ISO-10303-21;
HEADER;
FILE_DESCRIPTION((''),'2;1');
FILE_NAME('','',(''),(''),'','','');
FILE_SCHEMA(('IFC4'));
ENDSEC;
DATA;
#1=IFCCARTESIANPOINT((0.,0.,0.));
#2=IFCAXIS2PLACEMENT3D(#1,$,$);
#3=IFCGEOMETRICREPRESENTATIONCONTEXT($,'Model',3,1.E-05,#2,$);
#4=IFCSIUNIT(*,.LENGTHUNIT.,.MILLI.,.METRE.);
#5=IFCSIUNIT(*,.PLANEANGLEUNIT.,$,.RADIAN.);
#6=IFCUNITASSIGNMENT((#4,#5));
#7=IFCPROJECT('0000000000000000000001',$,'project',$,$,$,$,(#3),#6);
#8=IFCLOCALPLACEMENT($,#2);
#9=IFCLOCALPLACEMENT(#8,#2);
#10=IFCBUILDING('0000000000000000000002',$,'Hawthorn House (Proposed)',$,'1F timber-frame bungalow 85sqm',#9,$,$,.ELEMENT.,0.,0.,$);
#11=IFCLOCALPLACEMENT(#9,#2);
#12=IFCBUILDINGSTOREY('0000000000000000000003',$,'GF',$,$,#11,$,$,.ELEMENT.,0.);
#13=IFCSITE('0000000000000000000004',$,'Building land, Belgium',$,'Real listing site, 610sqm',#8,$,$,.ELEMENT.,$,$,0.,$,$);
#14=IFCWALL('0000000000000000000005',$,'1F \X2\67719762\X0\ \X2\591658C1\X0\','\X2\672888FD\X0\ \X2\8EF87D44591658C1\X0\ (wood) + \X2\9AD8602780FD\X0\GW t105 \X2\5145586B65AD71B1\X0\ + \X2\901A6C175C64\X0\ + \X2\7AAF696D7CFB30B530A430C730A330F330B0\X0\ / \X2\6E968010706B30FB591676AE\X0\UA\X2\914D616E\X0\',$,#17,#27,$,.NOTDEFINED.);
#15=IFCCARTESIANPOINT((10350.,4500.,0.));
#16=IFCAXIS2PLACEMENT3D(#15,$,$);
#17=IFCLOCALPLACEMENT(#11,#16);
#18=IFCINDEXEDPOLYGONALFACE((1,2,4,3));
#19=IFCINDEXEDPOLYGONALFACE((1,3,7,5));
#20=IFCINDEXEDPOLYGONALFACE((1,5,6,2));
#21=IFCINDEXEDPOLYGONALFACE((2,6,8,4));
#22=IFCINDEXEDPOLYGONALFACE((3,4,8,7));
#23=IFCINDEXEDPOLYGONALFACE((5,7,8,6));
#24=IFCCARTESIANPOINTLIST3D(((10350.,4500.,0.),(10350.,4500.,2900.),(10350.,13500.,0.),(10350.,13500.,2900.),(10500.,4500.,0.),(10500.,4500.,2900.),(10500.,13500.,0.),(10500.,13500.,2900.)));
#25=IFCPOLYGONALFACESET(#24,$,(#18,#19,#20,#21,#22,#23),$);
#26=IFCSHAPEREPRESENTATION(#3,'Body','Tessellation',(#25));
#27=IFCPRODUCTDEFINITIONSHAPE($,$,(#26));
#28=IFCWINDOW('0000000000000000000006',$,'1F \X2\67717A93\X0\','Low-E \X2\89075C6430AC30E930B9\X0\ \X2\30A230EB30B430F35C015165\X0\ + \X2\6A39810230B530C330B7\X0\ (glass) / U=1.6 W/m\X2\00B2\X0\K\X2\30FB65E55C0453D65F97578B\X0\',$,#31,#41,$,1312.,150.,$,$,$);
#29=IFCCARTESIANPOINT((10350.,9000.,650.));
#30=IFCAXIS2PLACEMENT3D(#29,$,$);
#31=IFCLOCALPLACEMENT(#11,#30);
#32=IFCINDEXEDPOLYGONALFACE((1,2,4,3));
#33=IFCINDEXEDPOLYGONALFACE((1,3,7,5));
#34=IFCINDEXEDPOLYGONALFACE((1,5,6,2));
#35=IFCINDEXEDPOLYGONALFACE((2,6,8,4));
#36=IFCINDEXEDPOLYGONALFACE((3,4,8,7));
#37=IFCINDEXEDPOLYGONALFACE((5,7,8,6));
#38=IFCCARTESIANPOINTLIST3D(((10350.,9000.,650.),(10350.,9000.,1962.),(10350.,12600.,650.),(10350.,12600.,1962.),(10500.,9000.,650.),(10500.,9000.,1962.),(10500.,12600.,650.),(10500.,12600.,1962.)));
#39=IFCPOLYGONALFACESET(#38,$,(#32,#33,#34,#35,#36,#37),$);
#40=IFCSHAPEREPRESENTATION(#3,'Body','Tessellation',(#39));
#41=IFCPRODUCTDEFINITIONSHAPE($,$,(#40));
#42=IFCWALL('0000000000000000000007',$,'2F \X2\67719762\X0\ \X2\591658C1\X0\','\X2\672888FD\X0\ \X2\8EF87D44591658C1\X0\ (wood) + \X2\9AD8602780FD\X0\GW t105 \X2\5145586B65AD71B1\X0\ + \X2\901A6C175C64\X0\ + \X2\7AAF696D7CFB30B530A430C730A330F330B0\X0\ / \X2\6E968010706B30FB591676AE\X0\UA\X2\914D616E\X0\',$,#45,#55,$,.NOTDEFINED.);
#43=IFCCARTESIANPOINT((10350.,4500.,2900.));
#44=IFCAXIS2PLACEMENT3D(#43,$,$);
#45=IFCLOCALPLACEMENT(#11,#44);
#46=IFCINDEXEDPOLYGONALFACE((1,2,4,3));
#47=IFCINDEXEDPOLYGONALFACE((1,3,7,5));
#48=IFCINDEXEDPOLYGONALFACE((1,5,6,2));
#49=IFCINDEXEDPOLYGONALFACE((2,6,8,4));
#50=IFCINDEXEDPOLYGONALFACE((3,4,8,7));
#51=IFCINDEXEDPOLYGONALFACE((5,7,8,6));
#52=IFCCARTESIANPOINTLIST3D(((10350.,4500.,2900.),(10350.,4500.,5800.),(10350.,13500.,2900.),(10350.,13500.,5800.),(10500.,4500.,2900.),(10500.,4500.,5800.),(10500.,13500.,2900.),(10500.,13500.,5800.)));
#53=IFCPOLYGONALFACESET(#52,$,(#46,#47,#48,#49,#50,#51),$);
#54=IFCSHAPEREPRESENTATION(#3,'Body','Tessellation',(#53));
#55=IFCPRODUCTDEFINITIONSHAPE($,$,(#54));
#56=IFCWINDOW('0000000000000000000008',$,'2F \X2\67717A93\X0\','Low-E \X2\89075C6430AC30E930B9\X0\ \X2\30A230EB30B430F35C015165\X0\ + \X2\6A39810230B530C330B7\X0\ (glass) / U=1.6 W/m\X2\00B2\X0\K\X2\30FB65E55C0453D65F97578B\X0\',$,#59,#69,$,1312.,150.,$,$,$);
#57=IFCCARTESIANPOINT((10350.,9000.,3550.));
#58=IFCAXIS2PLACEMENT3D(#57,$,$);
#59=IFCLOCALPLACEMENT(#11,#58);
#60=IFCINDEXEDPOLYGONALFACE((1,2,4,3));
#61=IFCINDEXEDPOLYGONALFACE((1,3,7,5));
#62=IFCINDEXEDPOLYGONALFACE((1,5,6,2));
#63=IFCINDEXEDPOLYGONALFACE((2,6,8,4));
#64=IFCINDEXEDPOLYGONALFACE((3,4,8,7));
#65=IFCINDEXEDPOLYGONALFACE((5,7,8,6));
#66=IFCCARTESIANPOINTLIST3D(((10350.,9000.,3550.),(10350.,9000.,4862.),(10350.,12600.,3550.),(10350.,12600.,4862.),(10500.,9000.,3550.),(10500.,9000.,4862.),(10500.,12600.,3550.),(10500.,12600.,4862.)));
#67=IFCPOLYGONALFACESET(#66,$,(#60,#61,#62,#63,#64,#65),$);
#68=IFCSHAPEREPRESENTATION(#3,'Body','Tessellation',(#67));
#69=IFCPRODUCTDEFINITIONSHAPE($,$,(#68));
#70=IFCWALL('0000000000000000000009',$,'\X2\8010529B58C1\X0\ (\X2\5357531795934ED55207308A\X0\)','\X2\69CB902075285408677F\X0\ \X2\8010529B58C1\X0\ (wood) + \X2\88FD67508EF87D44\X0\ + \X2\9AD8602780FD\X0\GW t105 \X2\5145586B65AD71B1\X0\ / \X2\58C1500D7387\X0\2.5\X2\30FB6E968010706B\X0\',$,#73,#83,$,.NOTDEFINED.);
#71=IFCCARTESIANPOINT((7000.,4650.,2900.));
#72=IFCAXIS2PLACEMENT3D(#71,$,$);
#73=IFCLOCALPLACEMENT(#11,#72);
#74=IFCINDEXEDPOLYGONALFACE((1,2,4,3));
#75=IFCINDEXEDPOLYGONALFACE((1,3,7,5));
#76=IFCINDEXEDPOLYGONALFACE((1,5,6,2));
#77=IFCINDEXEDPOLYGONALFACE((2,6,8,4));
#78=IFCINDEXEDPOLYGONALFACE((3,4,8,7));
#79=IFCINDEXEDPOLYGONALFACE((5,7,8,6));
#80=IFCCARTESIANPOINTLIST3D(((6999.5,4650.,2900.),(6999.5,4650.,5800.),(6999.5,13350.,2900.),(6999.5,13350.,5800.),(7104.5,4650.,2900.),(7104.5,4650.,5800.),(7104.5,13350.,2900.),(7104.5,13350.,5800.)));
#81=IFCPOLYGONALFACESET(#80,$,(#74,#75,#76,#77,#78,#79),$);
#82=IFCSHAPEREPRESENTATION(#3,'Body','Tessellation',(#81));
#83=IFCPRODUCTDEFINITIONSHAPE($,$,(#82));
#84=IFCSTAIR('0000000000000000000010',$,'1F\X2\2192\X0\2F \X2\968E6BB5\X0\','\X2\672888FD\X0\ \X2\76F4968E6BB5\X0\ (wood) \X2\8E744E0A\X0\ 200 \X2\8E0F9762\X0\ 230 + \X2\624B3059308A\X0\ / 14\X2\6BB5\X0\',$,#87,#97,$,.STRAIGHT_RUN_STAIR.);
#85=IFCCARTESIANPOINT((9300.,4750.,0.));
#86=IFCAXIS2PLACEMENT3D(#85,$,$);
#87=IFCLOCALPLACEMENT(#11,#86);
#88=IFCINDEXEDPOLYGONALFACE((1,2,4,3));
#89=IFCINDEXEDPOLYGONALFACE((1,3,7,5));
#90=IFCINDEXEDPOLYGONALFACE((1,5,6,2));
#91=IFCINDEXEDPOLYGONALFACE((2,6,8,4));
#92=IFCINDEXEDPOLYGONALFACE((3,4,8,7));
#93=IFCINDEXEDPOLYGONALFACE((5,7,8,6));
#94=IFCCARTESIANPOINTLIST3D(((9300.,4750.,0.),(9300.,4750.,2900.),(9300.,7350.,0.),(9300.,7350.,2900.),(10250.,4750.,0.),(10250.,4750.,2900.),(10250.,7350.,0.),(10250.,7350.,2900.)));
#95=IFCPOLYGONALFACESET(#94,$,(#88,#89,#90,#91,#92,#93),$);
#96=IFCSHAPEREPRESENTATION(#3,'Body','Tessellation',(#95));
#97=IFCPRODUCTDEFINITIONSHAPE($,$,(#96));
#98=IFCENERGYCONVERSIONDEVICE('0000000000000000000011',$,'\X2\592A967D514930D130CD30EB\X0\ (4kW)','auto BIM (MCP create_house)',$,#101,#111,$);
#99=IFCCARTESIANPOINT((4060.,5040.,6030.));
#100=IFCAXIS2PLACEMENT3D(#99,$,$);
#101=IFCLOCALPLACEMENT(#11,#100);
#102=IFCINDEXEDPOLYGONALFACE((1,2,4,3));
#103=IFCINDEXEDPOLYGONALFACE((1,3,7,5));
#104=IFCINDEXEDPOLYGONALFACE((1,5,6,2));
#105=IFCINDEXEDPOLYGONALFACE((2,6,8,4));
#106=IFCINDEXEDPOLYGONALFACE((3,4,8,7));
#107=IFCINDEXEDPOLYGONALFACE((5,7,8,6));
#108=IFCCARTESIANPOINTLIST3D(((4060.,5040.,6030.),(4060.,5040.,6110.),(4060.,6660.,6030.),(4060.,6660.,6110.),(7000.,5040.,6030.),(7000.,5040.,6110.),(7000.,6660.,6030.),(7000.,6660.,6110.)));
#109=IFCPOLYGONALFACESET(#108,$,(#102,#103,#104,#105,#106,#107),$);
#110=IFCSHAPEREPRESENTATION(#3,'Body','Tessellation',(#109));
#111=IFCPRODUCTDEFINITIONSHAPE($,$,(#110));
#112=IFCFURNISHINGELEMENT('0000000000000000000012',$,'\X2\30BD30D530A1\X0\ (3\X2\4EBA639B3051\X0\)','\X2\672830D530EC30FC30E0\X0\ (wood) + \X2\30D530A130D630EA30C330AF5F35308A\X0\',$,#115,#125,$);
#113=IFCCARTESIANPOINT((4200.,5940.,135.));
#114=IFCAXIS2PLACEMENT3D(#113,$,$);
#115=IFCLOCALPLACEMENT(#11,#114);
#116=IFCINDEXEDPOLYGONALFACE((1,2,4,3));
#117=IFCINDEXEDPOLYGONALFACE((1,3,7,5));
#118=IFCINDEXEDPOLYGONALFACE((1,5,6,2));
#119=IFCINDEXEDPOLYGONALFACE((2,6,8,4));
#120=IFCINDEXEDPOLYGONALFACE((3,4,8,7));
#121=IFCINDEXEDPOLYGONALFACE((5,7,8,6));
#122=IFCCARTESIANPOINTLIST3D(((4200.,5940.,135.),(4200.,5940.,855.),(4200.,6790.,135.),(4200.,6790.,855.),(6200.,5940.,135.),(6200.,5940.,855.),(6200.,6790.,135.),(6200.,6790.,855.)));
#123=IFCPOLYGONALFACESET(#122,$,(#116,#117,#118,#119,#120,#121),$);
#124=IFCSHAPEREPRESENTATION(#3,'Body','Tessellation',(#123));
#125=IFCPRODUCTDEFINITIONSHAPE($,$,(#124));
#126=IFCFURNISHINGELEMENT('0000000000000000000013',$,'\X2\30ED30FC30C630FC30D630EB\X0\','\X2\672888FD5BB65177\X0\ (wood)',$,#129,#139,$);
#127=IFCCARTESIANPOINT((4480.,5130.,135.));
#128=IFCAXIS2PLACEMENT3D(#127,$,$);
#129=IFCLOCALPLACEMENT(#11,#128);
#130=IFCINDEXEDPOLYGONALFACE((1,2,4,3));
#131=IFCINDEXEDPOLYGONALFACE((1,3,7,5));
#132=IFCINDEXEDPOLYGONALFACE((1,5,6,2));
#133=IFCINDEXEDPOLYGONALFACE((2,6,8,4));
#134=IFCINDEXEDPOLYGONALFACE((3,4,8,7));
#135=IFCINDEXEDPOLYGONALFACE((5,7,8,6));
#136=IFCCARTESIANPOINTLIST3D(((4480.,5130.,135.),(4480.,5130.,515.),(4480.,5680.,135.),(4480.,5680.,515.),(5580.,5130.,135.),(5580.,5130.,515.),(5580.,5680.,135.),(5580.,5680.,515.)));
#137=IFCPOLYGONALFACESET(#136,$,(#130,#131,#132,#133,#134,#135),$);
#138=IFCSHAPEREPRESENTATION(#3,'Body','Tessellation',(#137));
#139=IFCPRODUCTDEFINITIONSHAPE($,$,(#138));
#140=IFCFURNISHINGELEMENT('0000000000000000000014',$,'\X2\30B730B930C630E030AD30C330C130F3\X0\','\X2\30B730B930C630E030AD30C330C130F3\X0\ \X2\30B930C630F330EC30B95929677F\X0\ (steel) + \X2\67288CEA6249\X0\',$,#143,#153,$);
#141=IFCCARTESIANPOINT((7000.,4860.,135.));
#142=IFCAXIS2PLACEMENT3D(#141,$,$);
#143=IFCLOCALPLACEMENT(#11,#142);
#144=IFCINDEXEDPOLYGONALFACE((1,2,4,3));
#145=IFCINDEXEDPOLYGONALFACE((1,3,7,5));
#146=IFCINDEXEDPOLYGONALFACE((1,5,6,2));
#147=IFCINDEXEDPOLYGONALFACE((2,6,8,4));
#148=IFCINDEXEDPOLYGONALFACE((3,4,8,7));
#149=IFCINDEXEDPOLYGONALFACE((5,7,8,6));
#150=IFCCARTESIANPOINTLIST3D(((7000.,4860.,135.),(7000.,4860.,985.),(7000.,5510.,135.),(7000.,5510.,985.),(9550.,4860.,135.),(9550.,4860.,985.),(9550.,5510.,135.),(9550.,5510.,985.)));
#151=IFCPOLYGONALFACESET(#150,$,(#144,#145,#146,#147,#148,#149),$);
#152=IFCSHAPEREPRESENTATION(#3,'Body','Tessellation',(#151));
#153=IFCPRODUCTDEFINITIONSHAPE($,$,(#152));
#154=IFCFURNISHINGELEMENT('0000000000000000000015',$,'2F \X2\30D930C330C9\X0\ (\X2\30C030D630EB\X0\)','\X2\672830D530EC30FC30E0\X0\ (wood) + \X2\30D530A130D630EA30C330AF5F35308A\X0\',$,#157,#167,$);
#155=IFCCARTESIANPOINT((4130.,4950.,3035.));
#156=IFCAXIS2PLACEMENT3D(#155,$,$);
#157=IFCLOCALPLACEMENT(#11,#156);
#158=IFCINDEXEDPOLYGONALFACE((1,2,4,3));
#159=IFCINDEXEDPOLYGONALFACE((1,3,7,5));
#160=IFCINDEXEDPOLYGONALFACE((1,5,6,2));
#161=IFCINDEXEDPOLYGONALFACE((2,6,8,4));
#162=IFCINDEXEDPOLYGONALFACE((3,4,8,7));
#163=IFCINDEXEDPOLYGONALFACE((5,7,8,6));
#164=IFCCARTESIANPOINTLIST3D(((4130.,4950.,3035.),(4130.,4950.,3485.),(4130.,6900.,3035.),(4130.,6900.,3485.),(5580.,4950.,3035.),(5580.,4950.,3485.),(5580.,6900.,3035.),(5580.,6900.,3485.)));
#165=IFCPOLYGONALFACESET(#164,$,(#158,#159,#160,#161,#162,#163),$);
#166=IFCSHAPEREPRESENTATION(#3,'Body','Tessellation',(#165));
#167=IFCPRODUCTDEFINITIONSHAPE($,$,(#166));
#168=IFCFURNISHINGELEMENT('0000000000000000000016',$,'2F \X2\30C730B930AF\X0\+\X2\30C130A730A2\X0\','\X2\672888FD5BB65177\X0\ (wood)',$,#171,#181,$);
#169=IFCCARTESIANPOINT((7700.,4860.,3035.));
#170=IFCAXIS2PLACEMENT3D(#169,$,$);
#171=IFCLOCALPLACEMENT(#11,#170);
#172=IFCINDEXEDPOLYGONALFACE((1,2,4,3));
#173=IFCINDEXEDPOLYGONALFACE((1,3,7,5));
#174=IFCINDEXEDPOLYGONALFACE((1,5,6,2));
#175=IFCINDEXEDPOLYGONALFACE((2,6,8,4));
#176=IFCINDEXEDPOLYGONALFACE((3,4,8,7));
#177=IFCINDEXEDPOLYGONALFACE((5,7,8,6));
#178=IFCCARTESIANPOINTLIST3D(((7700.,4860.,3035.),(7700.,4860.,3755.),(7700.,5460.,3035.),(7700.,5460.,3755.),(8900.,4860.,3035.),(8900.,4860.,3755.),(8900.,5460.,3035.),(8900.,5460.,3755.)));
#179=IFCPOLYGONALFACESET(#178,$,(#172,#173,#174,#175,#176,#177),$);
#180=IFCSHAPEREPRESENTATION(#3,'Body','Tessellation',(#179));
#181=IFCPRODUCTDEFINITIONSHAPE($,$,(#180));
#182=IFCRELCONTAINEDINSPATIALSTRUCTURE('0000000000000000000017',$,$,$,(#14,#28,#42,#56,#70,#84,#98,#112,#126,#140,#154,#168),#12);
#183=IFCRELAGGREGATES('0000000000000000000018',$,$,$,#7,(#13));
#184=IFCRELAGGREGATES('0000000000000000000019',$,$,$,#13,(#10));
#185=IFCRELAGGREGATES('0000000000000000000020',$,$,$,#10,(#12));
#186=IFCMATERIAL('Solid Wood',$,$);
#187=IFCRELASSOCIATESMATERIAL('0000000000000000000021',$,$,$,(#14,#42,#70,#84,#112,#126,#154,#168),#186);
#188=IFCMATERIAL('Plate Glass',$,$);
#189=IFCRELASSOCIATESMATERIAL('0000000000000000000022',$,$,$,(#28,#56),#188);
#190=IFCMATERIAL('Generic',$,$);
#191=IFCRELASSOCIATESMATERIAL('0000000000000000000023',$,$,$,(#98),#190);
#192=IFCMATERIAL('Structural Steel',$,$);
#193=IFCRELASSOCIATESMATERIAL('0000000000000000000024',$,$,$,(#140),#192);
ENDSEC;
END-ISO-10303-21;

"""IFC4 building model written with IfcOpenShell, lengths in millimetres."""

from ifc_helpers import new_model, si_unit, frame, frame_2d, origin, place, context, project, spatial, rectangle, extrude, material, element, fill, save


model = new_model("IFC4")

# Units and contexts
model_context = context("Model", 3, precision=1e-05, world=origin())
ifc_project = project(units=[si_unit("LENGTHUNIT", "METRE", prefix="MILLI"), si_unit("PLANEANGLEUNIT", "RADIAN")], contexts=[model_context])

# Site, building, storey
site_placement = place(None, origin())
site = spatial("IfcSite", under=ifc_project, at=site_placement, Name="Building land, Belgium", ObjectType="Real listing site, 610sqm", CompositionType="ELEMENT", RefElevation=0.0)
building_placement = place(site_placement, origin())
building = spatial("IfcBuilding", under=site, at=building_placement, Name="Hawthorn House (Proposed)", ObjectType="1F timber-frame bungalow 85sqm", CompositionType="ELEMENT", ElevationOfRefHeight=0.0, ElevationOfTerrain=0.0)
storey_placement = place(building_placement, origin())
storey = spatial("IfcBuildingStorey", under=building, at=storey_placement, Name="GF", CompositionType="ELEMENT", Elevation=0.0)

# Wall, opening, window
ifc_material_1 = material(Name="Solid Wood")
wall_1_placement = place(storey_placement, frame((10350.0, 4500.0, 0.0)))
wall_1 = element("IfcWall", 1, at=wall_1_placement, inside=storey, material=ifc_material_1, Name="1F 東面 外壁", Description="木製 軸組外壁 (wood) + 高性能GW t105 充填断熱 + 通気層 + 窯業系サイディング / 準耐火・外皮UA配慮", PredefinedType="NOTDEFINED", context=model_context, shape_type="SweptSolid", body=[
    extrude(rectangle(XDim=150.0, YDim=9000.0, at=frame_2d((75.0, 4500.0))), frame((10350.0, 4500.0, 0.0)), (0.0, 0.0, 1.0), 2900.0),
])
opening_1_placement = place(storey_placement, frame((10350.0, 9000.0, 650.0)))
opening_1 = element("IfcOpeningElement", 2, at=opening_1_placement, cuts=wall_1, PredefinedType="NOTDEFINED", context=model_context, shape_type="SweptSolid", body=[
    extrude(rectangle(XDim=150.0, YDim=3600.0, at=frame_2d((75.0, 1800.0))), frame((10350.0, 9000.0, 650.0)), (0.0, 0.0, 1.0), 1312.0),
])
ifc_material_2 = material(Name="Plate Glass")
window_1_placement = place(storey_placement, frame((10350.0, 9000.0, 650.0)))
window_1 = element("IfcWindow", 3, at=window_1_placement, inside=storey, material=ifc_material_2, Name="1F 東窓", Description="Low-E 複層ガラス アルゴン封入 + 樹脂サッシ (glass) / U=1.6 W/m²K・日射取得型", OverallHeight=1312.0, OverallWidth=150.0, context=model_context, shape_type="SweptSolid", body=[
    extrude(rectangle(XDim=150.0, YDim=3600.0, at=frame_2d((75.0, 1800.0))), frame((10350.0, 9000.0, 650.0)), (0.0, 0.0, 1.0), 1312.0),
])
fill(opening_1, window_1)

# Wall, opening, window
wall_2_placement = place(storey_placement, frame((10350.0, 4500.0, 2900.0)))
wall_2 = element("IfcWall", 4, at=wall_2_placement, inside=storey, material=ifc_material_1, Name="2F 東面 外壁", Description="木製 軸組外壁 (wood) + 高性能GW t105 充填断熱 + 通気層 + 窯業系サイディング / 準耐火・外皮UA配慮", PredefinedType="NOTDEFINED", context=model_context, shape_type="SweptSolid", body=[
    extrude(rectangle(XDim=150.0, YDim=9000.0, at=frame_2d((75.0, 4500.0))), frame((10350.0, 4500.0, 2900.0)), (0.0, 0.0, 1.0), 2900.0),
])
opening_2_placement = place(storey_placement, frame((10350.0, 9000.0, 3550.0)))
opening_2 = element("IfcOpeningElement", 5, at=opening_2_placement, cuts=wall_2, PredefinedType="NOTDEFINED", context=model_context, shape_type="SweptSolid", body=[
    extrude(rectangle(XDim=150.0, YDim=3600.0, at=frame_2d((75.0, 1800.0))), frame((10350.0, 9000.0, 3550.0)), (0.0, 0.0, 1.0), 1312.0),
])
window_2_placement = place(storey_placement, frame((10350.0, 9000.0, 3550.0)))
window_2 = element("IfcWindow", 6, at=window_2_placement, inside=storey, material=ifc_material_2, Name="2F 東窓", Description="Low-E 複層ガラス アルゴン封入 + 樹脂サッシ (glass) / U=1.6 W/m²K・日射取得型", OverallHeight=1312.0, OverallWidth=150.0, context=model_context, shape_type="SweptSolid", body=[
    extrude(rectangle(XDim=150.0, YDim=3600.0, at=frame_2d((75.0, 1800.0))), frame((10350.0, 9000.0, 3550.0)), (0.0, 0.0, 1.0), 1312.0),
])
fill(opening_2, window_2)

# Wall
wall_3_placement = place(storey_placement, frame((7000.0, 4650.0, 2900.0)))
element("IfcWall", 7, at=wall_3_placement, inside=storey, material=ifc_material_1, Name="耐力壁 (南北間仕切り)", Description="構造用合板 耐力壁 (wood) + 製材軸組 + 高性能GW t105 充填断熱 / 壁倍率2.5・準耐火", PredefinedType="NOTDEFINED", context=model_context, shape_type="SweptSolid", body=[
    extrude(rectangle(XDim=105.0, YDim=8700.0, at=frame_2d((52.0, 4350.0))), frame((7000.0, 4650.0, 2900.0)), (0.0, 0.0, 1.0), 2900.0),
])

# Stair
stair_placement = place(storey_placement, frame((9300.0, 4750.0, 0.0)))
element("IfcStair", 8, at=stair_placement, inside=storey, material=ifc_material_1, Name="1F→2F 階段", Description="木製 直階段 (wood) 蹴上 200 踏面 230 + 手すり / 14段", PredefinedType="STRAIGHT_RUN_STAIR", context=model_context, shape_type="SweptSolid", body=[
    extrude(rectangle(XDim=950.0, YDim=2600.0, at=frame_2d((475.0, 1300.0))), frame((9300.0, 4750.0, 0.0)), (0.0, 0.0, 1.0), 2900.0),
])

# Energy conversion device
ifc_material_3 = material(Name="Generic")
energy_conversion_device_placement = place(storey_placement, frame((4060.0, 5040.0, 6030.0)))
element("IfcEnergyConversionDevice", 9, at=energy_conversion_device_placement, inside=storey, material=ifc_material_3, Name="太陽光パネル (4kW)", Description="auto BIM (MCP create_house)", context=model_context, shape_type="SweptSolid", body=[
    extrude(rectangle(XDim=2940.0, YDim=1620.0, at=frame_2d((1470.0, 810.0))), frame((4060.0, 5040.0, 6030.0)), (0.0, 0.0, 1.0), 80.0),
])

# Furnishing elements
furnishing_1_placement = place(storey_placement, frame((4200.0, 5940.0, 135.0)))
element("IfcFurnishingElement", 10, at=furnishing_1_placement, inside=storey, material=ifc_material_1, Name="ソファ (3人掛け)", Description="木フレーム (wood) + ファブリック張り", context=model_context, shape_type="SweptSolid", body=[
    extrude(rectangle(XDim=2000.0, YDim=850.0, at=frame_2d((1000.0, 425.0))), frame((4200.0, 5940.0, 135.0)), (0.0, 0.0, 1.0), 720.0),
])
furnishing_2_placement = place(storey_placement, frame((4480.0, 5130.0, 135.0)))
element("IfcFurnishingElement", 11, at=furnishing_2_placement, inside=storey, material=ifc_material_1, Name="ローテーブル", Description="木製家具 (wood)", context=model_context, shape_type="SweptSolid", body=[
    extrude(rectangle(XDim=1100.0, YDim=550.0, at=frame_2d((550.0, 275.0))), frame((4480.0, 5130.0, 135.0)), (0.0, 0.0, 1.0), 380.0),
])
ifc_material_4 = material(Name="Structural Steel")
furnishing_3_placement = place(storey_placement, frame((7000.0, 4860.0, 135.0)))
element("IfcFurnishingElement", 12, at=furnishing_3_placement, inside=storey, material=ifc_material_4, Name="システムキッチン", Description="システムキッチン ステンレス天板 (steel) + 木質扉", context=model_context, shape_type="SweptSolid", body=[
    extrude(rectangle(XDim=2550.0, YDim=650.0, at=frame_2d((1275.0, 325.0))), frame((7000.0, 4860.0, 135.0)), (0.0, 0.0, 1.0), 850.0),
])
furnishing_4_placement = place(storey_placement, frame((4130.0, 4950.0, 3035.0)))
element("IfcFurnishingElement", 13, at=furnishing_4_placement, inside=storey, material=ifc_material_1, Name="2F ベッド (ダブル)", Description="木フレーム (wood) + ファブリック張り", context=model_context, shape_type="SweptSolid", body=[
    extrude(rectangle(XDim=1450.0, YDim=1950.0, at=frame_2d((725.0, 975.0))), frame((4130.0, 4950.0, 3035.0)), (0.0, 0.0, 1.0), 450.0),
])
furnishing_5_placement = place(storey_placement, frame((7700.0, 4860.0, 3035.0)))
element("IfcFurnishingElement", 14, at=furnishing_5_placement, inside=storey, material=ifc_material_1, Name="2F デスク+チェア", Description="木製家具 (wood)", context=model_context, shape_type="SweptSolid", body=[
    extrude(rectangle(XDim=1200.0, YDim=600.0, at=frame_2d((600.0, 300.0))), frame((7700.0, 4860.0, 3035.0)), (0.0, 0.0, 1.0), 720.0),
])

save(model, "model.ifc")
